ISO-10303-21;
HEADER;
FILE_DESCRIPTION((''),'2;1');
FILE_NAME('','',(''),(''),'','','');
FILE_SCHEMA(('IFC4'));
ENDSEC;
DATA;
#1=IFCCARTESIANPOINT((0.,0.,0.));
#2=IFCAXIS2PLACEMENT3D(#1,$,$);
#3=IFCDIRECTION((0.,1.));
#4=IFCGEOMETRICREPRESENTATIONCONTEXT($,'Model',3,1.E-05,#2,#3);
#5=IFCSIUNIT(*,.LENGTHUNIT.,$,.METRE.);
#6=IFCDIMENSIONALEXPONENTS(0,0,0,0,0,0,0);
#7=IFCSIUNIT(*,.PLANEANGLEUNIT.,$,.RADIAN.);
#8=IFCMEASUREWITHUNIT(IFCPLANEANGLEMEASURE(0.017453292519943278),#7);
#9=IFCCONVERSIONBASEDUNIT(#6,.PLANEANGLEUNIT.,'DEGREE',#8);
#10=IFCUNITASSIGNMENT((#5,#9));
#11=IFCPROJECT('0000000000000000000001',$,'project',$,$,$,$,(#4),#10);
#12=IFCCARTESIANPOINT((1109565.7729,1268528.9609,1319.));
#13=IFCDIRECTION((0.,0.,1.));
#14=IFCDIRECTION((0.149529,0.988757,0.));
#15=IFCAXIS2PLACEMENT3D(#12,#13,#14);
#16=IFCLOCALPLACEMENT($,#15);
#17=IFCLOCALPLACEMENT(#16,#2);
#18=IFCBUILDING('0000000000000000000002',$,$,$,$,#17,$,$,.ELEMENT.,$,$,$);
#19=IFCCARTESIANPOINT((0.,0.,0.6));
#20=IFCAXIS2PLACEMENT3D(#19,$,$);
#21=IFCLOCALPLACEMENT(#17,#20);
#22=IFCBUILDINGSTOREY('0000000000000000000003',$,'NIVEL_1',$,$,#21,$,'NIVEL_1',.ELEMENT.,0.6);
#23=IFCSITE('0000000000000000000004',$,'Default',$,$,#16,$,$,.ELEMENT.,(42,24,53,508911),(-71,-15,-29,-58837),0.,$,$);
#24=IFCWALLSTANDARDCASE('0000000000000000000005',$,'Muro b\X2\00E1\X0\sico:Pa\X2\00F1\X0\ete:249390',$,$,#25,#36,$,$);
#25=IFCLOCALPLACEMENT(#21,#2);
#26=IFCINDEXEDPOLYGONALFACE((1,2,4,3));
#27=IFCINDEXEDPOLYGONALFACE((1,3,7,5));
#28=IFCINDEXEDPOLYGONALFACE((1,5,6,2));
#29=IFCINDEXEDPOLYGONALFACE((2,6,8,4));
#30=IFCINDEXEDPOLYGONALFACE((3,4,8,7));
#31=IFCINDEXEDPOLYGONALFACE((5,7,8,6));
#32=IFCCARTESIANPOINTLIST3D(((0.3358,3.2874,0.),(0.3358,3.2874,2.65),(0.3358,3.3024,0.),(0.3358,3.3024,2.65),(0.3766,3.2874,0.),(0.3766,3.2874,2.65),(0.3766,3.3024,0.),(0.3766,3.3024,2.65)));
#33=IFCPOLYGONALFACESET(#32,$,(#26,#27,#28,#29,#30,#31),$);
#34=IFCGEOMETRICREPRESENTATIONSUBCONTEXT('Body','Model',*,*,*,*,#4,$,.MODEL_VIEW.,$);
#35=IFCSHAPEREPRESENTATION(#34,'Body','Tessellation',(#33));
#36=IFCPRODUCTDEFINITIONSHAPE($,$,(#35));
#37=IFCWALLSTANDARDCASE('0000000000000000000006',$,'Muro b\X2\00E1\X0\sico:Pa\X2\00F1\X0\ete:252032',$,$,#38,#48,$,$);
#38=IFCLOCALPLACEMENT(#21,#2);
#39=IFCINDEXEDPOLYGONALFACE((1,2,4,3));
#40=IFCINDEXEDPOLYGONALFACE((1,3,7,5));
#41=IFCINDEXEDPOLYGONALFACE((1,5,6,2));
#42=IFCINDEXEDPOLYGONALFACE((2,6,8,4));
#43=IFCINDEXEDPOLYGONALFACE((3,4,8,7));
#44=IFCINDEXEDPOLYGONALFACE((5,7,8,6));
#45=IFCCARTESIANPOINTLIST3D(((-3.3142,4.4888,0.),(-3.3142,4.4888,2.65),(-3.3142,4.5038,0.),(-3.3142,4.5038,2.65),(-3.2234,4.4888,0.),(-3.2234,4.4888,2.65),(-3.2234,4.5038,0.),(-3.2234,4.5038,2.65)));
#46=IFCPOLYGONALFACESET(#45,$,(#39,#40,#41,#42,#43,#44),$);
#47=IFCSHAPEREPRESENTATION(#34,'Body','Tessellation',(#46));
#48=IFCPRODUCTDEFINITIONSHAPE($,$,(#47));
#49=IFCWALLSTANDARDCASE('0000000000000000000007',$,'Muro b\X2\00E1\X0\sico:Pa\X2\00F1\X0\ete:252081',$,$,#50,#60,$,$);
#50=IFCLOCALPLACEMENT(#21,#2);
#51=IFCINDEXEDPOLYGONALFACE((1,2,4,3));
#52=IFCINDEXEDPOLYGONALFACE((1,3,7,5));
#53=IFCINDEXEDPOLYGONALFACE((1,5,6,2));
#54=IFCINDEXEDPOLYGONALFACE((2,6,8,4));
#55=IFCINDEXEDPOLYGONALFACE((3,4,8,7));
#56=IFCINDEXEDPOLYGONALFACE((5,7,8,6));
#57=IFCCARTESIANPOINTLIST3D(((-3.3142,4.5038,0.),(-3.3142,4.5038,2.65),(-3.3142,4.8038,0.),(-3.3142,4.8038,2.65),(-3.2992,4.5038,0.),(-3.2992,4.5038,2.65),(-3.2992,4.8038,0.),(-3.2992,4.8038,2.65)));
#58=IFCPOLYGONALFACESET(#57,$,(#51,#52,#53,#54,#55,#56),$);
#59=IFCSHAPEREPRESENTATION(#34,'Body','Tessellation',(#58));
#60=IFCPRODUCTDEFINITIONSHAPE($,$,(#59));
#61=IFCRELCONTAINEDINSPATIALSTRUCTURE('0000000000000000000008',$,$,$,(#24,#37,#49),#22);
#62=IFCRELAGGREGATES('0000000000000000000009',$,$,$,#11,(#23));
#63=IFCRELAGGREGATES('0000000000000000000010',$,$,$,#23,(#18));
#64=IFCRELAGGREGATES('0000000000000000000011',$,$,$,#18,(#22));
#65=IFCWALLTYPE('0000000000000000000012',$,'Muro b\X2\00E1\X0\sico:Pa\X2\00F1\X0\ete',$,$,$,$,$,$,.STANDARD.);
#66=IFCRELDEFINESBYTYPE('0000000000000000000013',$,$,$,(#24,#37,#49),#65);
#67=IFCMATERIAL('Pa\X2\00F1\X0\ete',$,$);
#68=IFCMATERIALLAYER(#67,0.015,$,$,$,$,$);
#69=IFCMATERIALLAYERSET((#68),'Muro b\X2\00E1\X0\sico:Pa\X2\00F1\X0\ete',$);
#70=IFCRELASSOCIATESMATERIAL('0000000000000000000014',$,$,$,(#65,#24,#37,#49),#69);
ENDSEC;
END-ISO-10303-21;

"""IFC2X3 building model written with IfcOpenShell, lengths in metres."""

from ifc_helpers import new_model, entity, si_unit, converted_unit, direction, frame, frame_2d, origin, place, context, subcontext, project, spatial, rectangle, extrude, material, layer, layer_set, layer_usage, type_object, element, save


model = new_model("IFC2X3")

# Units and contexts
model_context = context("Model", 3, precision=1e-05, world=origin(), true_north=direction((0.0, 1.0)))
body_context = subcontext(model_context, "Body", "Model", "MODEL_VIEW")
ifc_project = project(units=[si_unit("LENGTHUNIT", "METRE"), converted_unit("PLANEANGLEUNIT", "DEGREE", entity("IfcPlaneAngleMeasure", 0.017453292519943278), si_unit("PLANEANGLEUNIT", "RADIAN"), dimensions=[0, 0, 0, 0, 0, 0, 0])], contexts=[model_context])

# Site, building, storey
site_placement = place(None, frame((1109565.7729, 1268528.9609, 1319.0), z_axis=(0.0, 0.0, 1.0), x_axis=(0.149529, 0.988757, 0.0)))
site = spatial("IfcSite", under=ifc_project, at=site_placement, Name="Default", CompositionType="ELEMENT", RefLatitude=(42, 24, 53, 508911), RefLongitude=(-71, -15, -29, -58837), RefElevation=0.0)
building_placement = place(site_placement, origin())
building = spatial("IfcBuilding", under=site, at=building_placement, CompositionType="ELEMENT")
storey_placement = place(building_placement, frame((0.0, 0.0, 0.6)))
storey = spatial("IfcBuildingStorey", under=building, at=storey_placement, Name="NIVEL_1", LongName="NIVEL_1", CompositionType="ELEMENT", Elevation=0.6)

# Shared definitions
ifc_material_1 = material(Name="Pañete")

# Walls
ifc_layer_1 = layer(ifc_material_1, 0.015)
ifc_layer_set_1 = layer_set([ifc_layer_1], Name="Muro básico:Pañete")
wall_type_1 = type_object("IfcWallType", Name="Muro básico:Pañete", PredefinedType="STANDARD", material=ifc_layer_set_1)
ifc_layer_usage_1 = layer_usage(ifc_layer_set_1, "AXIS2", "POSITIVE", -0.0075)
wall_1_placement = place(storey_placement, frame((0.3358, 3.2949, 0.0)))
element("IfcWallStandardCase", 1, at=wall_1_placement, inside=storey, type_object=wall_type_1, material=ifc_layer_usage_1, Name="Muro básico:Pañete:249390", context=body_context, shape_type="SweptSolid", body=[
    extrude(rectangle(XDim=0.0409, YDim=0.015, at=frame_2d((0.0204, 0.0), x_axis=(-1.0, 0.0))), origin(), (0.0, 0.0, 1.0), 2.65),
])
ifc_layer_usage_2 = layer_usage(ifc_layer_set_1, "AXIS2", "NEGATIVE", 0.0075)
wall_2_placement = place(storey_placement, frame((-3.2234, 4.4963, 0.0), z_axis=(0.0, 0.0, 1.0), x_axis=(-1.0, 0.0, 0.0)))
element("IfcWallStandardCase", 2, at=wall_2_placement, inside=storey, type_object=wall_type_1, material=ifc_layer_usage_2, Name="Muro básico:Pañete:252032", context=body_context, shape_type="SweptSolid", body=[
    extrude(rectangle(XDim=0.0909, YDim=0.015, at=frame_2d((0.0454, 0.0), x_axis=(-1.0, 0.0))), origin(), (0.0, 0.0, 1.0), 2.65),
])
ifc_layer_usage_3 = layer_usage(ifc_layer_set_1, "AXIS2", "NEGATIVE", 0.0075)
wall_3_placement = place(storey_placement, frame((-3.3067, 4.5038, 0.0), z_axis=(0.0, 0.0, 1.0), x_axis=(0.0, 1.0, 0.0)))
element("IfcWallStandardCase", 3, at=wall_3_placement, inside=storey, type_object=wall_type_1, material=ifc_layer_usage_3, Name="Muro básico:Pañete:252081", context=body_context, shape_type="SweptSolid", body=[
    extrude(rectangle(XDim=0.3, YDim=0.015, at=frame_2d((0.15, 0.0), x_axis=(-1.0, 0.0))), origin(), (0.0, 0.0, 1.0), 2.65),
])

save(model, "model.ifc")
